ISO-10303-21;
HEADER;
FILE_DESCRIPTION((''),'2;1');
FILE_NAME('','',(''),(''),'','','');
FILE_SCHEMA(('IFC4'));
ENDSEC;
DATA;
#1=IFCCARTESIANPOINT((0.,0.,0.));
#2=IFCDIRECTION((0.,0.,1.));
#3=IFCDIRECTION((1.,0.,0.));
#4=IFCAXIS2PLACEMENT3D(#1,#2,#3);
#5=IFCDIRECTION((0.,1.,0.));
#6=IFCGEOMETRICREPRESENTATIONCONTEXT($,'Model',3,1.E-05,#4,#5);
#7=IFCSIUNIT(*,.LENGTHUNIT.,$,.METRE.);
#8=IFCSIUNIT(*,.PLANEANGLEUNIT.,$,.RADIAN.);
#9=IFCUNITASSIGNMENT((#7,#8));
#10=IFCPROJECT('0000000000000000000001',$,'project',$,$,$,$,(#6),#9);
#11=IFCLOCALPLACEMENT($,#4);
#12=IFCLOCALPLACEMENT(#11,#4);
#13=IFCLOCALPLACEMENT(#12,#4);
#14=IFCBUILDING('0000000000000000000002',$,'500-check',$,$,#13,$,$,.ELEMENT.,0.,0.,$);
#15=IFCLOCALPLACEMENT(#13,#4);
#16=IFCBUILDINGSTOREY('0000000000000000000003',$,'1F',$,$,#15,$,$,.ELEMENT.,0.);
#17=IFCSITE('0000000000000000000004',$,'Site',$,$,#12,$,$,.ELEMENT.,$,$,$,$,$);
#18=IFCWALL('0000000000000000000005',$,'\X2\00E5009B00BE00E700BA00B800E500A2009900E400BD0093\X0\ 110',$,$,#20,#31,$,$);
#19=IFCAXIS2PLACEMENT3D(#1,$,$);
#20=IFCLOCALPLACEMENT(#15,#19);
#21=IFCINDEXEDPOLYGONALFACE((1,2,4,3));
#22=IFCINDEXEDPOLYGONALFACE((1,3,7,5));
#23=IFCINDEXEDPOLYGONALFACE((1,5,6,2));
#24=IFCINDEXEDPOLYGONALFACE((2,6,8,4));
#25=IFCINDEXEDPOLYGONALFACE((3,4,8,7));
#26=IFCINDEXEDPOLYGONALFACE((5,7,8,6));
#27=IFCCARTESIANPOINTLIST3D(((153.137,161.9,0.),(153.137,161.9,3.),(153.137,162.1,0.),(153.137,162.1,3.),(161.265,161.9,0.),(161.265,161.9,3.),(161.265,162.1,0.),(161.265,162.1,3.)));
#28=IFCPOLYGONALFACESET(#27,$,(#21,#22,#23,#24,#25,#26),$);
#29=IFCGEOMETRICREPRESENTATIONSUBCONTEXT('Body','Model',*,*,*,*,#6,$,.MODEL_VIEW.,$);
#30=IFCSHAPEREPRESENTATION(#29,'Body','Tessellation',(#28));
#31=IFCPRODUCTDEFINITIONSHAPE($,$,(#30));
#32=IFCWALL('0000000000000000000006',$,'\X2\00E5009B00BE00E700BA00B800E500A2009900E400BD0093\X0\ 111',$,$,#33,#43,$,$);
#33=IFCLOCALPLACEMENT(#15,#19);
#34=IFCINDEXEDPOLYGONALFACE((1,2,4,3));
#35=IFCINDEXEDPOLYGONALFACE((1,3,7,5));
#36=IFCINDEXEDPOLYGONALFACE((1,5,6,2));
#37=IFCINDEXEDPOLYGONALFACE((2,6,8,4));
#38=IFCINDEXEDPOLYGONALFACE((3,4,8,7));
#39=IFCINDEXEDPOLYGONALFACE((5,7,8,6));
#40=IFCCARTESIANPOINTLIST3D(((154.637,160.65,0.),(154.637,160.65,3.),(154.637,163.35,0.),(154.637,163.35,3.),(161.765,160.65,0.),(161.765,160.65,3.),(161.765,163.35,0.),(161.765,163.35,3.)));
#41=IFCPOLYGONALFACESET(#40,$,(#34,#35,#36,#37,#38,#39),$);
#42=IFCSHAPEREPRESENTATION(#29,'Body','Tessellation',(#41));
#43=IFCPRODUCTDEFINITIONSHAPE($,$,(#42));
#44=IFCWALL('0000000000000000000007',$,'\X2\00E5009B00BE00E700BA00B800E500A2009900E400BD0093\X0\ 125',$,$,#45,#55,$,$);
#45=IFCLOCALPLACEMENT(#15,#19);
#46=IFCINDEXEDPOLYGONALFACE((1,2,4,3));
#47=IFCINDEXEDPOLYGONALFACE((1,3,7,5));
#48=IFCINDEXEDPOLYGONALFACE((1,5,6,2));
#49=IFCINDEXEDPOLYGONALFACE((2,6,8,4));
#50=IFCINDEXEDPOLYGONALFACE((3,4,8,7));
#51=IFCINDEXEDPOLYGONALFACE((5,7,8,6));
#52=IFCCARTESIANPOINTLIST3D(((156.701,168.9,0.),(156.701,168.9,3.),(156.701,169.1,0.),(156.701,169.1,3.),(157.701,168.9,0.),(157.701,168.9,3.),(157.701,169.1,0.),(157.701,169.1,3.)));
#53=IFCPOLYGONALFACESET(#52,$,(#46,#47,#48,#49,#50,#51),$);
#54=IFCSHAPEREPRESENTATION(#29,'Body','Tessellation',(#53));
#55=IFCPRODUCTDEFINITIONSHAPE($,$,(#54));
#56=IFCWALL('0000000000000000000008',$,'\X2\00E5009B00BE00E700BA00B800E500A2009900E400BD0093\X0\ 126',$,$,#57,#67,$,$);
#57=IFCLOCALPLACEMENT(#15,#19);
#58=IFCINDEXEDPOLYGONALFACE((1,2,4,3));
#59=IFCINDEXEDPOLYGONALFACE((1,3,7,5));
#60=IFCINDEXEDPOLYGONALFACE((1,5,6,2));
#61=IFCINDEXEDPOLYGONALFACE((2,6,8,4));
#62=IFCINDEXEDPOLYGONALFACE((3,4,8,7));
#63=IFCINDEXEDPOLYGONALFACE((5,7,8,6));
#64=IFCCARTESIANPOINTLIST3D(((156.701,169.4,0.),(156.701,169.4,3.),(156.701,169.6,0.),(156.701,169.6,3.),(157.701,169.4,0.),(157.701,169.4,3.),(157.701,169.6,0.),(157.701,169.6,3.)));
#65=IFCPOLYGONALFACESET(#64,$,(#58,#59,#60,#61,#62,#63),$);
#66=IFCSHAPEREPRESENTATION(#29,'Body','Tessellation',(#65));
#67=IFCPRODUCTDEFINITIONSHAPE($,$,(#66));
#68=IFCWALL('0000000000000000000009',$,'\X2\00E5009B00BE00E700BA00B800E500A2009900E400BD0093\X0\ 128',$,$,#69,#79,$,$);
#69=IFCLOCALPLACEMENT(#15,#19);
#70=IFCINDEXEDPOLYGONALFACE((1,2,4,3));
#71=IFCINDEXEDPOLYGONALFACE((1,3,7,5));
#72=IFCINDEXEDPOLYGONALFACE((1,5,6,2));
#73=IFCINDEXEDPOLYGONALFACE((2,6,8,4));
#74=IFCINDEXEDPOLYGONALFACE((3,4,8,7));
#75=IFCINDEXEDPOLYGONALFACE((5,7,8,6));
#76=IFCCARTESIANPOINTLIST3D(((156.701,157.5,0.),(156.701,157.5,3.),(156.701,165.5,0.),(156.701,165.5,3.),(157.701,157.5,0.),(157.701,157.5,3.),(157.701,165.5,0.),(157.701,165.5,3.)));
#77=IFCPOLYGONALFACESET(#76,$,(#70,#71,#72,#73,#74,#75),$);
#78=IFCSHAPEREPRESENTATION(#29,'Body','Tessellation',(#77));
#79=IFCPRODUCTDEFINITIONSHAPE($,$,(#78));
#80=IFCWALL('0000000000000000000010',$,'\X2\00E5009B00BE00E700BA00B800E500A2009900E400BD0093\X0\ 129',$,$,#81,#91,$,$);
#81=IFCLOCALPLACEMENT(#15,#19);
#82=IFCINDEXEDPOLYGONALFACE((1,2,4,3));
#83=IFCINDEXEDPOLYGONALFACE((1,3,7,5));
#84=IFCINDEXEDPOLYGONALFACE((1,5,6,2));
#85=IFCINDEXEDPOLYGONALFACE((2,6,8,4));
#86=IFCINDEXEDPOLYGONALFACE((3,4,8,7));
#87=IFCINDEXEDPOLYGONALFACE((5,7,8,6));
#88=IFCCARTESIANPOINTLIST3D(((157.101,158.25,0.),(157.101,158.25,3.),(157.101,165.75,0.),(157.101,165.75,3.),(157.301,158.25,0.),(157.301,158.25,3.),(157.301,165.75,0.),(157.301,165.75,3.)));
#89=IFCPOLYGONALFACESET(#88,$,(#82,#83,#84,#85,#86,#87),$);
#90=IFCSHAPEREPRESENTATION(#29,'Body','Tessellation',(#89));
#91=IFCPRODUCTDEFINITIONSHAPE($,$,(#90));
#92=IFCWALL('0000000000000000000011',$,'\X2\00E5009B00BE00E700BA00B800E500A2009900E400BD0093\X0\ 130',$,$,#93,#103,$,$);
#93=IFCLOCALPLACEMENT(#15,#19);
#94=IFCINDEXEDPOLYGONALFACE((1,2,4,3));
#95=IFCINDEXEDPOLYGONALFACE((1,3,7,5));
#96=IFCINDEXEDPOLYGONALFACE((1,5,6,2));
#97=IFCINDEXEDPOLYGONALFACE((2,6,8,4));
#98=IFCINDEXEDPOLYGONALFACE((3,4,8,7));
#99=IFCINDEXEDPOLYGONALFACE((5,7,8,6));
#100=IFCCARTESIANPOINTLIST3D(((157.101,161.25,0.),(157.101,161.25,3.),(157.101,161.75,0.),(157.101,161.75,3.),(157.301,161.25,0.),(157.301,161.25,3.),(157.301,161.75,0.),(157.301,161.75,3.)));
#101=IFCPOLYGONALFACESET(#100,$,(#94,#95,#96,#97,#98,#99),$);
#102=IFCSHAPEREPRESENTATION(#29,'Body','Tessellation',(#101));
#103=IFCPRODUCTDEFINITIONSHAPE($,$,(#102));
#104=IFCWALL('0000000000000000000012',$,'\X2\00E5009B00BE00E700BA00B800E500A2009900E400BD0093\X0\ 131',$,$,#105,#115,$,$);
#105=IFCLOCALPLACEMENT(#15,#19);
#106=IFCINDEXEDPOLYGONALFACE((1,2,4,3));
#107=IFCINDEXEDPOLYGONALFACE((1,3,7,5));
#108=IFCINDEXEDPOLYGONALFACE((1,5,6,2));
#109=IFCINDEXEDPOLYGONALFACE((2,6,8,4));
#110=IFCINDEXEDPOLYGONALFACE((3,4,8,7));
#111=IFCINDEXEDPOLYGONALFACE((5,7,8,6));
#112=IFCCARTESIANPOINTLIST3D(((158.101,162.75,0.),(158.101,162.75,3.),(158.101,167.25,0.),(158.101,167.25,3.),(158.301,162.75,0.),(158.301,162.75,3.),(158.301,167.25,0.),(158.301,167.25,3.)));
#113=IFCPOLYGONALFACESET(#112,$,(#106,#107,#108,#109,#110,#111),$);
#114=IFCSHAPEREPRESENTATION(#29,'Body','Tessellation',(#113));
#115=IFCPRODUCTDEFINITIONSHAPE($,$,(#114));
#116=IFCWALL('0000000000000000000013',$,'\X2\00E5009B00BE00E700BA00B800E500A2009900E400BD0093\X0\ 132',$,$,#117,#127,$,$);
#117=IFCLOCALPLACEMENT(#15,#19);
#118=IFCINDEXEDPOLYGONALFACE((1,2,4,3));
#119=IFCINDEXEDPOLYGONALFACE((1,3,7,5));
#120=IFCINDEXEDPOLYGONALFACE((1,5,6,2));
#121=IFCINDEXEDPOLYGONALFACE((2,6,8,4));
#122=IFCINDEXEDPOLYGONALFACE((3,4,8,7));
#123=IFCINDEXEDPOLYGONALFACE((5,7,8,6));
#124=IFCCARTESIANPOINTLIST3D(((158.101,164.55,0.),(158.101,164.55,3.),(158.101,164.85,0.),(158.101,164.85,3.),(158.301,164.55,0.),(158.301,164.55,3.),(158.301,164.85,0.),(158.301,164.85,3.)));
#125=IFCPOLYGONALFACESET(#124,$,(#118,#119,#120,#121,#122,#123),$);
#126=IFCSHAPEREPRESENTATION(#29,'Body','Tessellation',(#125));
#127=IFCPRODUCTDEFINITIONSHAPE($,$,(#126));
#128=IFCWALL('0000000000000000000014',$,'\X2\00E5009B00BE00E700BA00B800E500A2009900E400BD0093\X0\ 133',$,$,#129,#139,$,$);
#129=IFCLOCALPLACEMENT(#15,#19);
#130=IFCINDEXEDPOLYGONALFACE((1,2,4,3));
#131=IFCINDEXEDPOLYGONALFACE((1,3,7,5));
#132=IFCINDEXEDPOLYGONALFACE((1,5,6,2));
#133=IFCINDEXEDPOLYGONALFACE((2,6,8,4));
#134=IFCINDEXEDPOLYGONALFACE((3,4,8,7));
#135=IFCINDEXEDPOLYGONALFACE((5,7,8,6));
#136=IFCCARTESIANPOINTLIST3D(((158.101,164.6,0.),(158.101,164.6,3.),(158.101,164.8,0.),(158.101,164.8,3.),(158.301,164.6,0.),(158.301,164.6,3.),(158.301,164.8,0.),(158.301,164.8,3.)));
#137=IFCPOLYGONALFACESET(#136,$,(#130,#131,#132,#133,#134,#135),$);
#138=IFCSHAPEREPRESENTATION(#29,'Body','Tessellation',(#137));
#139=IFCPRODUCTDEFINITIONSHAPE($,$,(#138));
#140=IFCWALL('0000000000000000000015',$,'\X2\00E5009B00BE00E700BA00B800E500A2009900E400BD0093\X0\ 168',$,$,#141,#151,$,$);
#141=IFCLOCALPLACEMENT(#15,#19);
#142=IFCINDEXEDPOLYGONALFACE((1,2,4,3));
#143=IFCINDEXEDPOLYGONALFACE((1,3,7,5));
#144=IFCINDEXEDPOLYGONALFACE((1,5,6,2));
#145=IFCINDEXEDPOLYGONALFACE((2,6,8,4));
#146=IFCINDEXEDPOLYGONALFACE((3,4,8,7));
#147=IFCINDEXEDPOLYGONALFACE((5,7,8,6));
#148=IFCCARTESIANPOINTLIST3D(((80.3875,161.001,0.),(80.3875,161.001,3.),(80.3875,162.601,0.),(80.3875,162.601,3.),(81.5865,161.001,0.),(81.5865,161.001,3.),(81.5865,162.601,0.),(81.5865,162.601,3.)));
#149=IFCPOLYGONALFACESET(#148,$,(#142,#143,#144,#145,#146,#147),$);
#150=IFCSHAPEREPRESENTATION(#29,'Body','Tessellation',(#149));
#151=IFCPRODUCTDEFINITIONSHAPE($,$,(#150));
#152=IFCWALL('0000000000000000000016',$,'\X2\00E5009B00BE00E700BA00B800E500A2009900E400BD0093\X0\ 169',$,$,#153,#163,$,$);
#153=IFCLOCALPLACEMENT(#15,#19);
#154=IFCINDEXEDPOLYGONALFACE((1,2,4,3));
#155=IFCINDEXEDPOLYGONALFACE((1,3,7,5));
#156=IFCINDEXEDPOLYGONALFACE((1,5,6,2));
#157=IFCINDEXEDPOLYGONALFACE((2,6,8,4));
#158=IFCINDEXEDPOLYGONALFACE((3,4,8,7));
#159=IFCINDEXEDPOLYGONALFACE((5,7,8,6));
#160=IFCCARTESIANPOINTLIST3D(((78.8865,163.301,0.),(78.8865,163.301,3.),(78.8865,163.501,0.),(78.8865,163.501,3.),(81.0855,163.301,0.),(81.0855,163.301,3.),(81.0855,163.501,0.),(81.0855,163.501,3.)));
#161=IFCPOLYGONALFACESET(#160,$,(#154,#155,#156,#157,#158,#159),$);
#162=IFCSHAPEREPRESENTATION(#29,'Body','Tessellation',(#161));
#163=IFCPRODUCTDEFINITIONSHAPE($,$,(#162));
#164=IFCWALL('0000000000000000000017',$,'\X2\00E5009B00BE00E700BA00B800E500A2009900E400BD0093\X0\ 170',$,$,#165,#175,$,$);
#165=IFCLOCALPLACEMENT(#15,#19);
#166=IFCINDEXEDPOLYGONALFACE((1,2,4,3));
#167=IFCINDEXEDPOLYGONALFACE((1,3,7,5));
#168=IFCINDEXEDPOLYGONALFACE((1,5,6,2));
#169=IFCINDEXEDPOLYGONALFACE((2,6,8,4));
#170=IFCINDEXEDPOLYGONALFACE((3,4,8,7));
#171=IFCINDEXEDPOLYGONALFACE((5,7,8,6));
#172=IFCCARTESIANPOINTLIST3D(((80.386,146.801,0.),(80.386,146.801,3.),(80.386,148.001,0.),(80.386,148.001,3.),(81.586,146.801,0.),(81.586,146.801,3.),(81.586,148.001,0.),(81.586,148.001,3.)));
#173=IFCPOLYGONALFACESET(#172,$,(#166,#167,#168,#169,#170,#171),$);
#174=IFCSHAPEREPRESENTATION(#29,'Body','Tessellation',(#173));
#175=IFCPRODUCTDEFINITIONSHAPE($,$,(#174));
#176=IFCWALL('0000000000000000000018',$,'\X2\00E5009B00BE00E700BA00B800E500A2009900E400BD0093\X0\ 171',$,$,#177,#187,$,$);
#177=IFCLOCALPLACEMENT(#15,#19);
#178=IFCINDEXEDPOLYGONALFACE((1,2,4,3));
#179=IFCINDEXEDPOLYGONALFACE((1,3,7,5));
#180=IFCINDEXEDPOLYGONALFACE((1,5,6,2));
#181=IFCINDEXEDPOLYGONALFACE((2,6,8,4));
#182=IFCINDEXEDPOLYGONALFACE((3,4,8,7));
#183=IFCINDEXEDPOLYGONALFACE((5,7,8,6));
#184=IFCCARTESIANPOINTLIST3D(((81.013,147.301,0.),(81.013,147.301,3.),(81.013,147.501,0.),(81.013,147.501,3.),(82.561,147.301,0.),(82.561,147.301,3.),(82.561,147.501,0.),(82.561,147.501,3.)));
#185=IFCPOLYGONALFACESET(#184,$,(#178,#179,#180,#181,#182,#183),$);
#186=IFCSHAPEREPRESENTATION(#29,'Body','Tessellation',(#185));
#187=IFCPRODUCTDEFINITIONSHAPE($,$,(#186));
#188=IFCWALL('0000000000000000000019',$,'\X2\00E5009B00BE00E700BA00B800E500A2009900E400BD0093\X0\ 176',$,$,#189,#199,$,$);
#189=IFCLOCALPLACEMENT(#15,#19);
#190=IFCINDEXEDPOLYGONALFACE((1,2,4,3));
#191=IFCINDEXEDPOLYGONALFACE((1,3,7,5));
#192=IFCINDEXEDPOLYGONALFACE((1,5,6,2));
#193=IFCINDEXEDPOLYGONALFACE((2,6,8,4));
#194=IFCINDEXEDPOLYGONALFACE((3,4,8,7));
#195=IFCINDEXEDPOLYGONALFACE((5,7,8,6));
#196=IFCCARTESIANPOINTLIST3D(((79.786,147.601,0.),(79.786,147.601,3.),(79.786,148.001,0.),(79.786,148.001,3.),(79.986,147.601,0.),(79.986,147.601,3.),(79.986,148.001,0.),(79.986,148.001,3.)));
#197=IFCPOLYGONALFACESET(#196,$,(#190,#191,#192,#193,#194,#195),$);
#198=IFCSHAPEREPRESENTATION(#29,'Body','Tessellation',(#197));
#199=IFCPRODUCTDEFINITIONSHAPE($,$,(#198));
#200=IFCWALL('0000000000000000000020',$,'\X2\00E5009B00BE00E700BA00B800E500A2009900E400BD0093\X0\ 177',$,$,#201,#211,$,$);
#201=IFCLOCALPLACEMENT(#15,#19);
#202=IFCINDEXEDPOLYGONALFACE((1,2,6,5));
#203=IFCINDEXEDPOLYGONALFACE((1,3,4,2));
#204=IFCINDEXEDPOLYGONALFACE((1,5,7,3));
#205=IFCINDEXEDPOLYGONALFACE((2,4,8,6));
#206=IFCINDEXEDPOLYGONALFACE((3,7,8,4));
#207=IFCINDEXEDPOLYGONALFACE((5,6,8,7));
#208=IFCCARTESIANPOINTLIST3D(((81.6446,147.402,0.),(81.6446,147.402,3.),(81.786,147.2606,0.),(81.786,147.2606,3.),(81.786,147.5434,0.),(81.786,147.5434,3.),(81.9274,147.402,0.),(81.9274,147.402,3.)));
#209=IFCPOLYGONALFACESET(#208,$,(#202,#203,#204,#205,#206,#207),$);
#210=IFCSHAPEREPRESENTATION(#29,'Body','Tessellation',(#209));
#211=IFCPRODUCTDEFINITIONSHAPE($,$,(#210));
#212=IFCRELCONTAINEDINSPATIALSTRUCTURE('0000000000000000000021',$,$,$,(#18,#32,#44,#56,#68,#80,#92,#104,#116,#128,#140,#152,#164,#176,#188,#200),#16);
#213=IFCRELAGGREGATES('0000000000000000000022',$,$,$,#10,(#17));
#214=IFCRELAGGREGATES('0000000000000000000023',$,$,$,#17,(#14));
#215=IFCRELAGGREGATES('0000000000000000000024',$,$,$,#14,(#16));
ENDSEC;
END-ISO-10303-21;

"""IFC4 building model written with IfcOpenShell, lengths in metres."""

from ifc_helpers import new_model, si_unit, direction, frame, frame_2d, origin_with_axes, place, context, subcontext, project, spatial, rectangle, extrude, element, save


model = new_model("IFC4")

# Units and contexts
model_context = context("Model", 3, precision=1e-05, world=origin_with_axes(), true_north=direction((0.0, 1.0, 0.0)))
body_context = subcontext(model_context, "Body", "Model", "MODEL_VIEW")
ifc_project = project(units=[si_unit("LENGTHUNIT", "METRE"), si_unit("PLANEANGLEUNIT", "RADIAN")], contexts=[model_context])

# Site, building, storey
placement = place(None, origin_with_axes())
site_placement = place(placement, origin_with_axes())
site = spatial("IfcSite", under=ifc_project, at=site_placement, Name="Site", CompositionType="ELEMENT")
building_placement = place(site_placement, origin_with_axes())
building = spatial("IfcBuilding", under=site, at=building_placement, Name="500-check", CompositionType="ELEMENT", ElevationOfRefHeight=0.0, ElevationOfTerrain=0.0)
storey_placement = place(building_placement, origin_with_axes())
storey = spatial("IfcBuildingStorey", under=building, at=storey_placement, Name="1F", CompositionType="ELEMENT", Elevation=0.0)

# Walls
wall_1_placement = place(storey_placement, frame((157.201, 162.0, 0.0), z_axis=(0.0, 0.0, 1.0), x_axis=(1.0, 0.0, 0.0)))
element("IfcWall", 1, at=wall_1_placement, inside=storey, Name="å\u009b¾çº¸å¢\u0099ä½\u0093 110", context=body_context, shape_type="SweptSolid", body=[
    extrude(rectangle(XDim=8.128, YDim=0.2, at=frame_2d((0.0, 0.0), x_axis=(1.0, 0.0, 0.0))), frame((0.0, 0.0, 0.0), z_axis=(0.0, 0.0, 1.0)), (0.0, 0.0, 1.0), 3.0),
])
wall_2_placement = place(storey_placement, frame((158.201, 162.0, 0.0), z_axis=(0.0, 0.0, 1.0), x_axis=(1.0, 0.0, 0.0)))
element("IfcWall", 2, at=wall_2_placement, inside=storey, Name="å\u009b¾çº¸å¢\u0099ä½\u0093 111", context=body_context, shape_type="SweptSolid", body=[
    extrude(rectangle(XDim=7.128, YDim=2.7, at=frame_2d((0.0, 0.0), x_axis=(1.0, 0.0, 0.0))), frame((0.0, 0.0, 0.0), z_axis=(0.0, 0.0, 1.0)), (0.0, 0.0, 1.0), 3.0),
])
for number, where, z_axis, x_axis, name in (
    (3, (157.201, 169.0, 0.0), (0.0, 0.0, 1.0), (1.0, 0.0, 0.0), "å\u009b¾çº¸å¢\u0099ä½\u0093 125"),
    (4, (157.201, 169.5, 0.0), (0.0, 0.0, 1.0), (1.0, 0.0, 0.0), "å\u009b¾çº¸å¢\u0099ä½\u0093 126"),
):
    element("IfcWall", number, at=place(storey_placement, frame(where, z_axis=z_axis, x_axis=x_axis)), inside=storey, Name=name, context=body_context, shape_type="SweptSolid", body=[
        extrude(rectangle(XDim=1.0, YDim=0.2, at=frame_2d((0.0, 0.0), x_axis=(1.0, 0.0, 0.0))), frame((0.0, 0.0, 0.0), z_axis=(0.0, 0.0, 1.0)), (0.0, 0.0, 1.0), 3.0),
    ])
wall_3_placement = place(storey_placement, frame((157.201, 161.5, 0.0), z_axis=(0.0, 0.0, 1.0), x_axis=(1.0, 0.0, 0.0)))
element("IfcWall", 5, at=wall_3_placement, inside=storey, Name="å\u009b¾çº¸å¢\u0099ä½\u0093 128", context=body_context, shape_type="SweptSolid", body=[
    extrude(rectangle(XDim=1.0, YDim=8.0, at=frame_2d((0.0, 0.0), x_axis=(1.0, 0.0, 0.0))), frame((0.0, 0.0, 0.0), z_axis=(0.0, 0.0, 1.0)), (0.0, 0.0, 1.0), 3.0),
])
wall_4_placement = place(storey_placement, frame((157.201, 162.0, 0.0), z_axis=(0.0, 0.0, 1.0), x_axis=(0.0, 1.0, 0.0)))
element("IfcWall", 6, at=wall_4_placement, inside=storey, Name="å\u009b¾çº¸å¢\u0099ä½\u0093 129", context=body_context, shape_type="SweptSolid", body=[
    extrude(rectangle(XDim=7.5, YDim=0.2, at=frame_2d((0.0, 0.0), x_axis=(1.0, 0.0, 0.0))), frame((0.0, 0.0, 0.0), z_axis=(0.0, 0.0, 1.0)), (0.0, 0.0, 1.0), 3.0),
])
wall_5_placement = place(storey_placement, frame((157.201, 161.5, 0.0), z_axis=(0.0, 0.0, 1.0), x_axis=(0.0, 1.0, 0.0)))
element("IfcWall", 7, at=wall_5_placement, inside=storey, Name="å\u009b¾çº¸å¢\u0099ä½\u0093 130", context=body_context, shape_type="SweptSolid", body=[
    extrude(rectangle(XDim=0.5, YDim=0.2, at=frame_2d((0.0, 0.0), x_axis=(1.0, 0.0, 0.0))), frame((0.0, 0.0, 0.0), z_axis=(0.0, 0.0, 1.0)), (0.0, 0.0, 1.0), 3.0),
])
wall_6_placement = place(storey_placement, frame((158.201, 165.0, 0.0), z_axis=(0.0, 0.0, 1.0), x_axis=(0.0, 1.0, 0.0)))
element("IfcWall", 8, at=wall_6_placement, inside=storey, Name="å\u009b¾çº¸å¢\u0099ä½\u0093 131", context=body_context, shape_type="SweptSolid", body=[
    extrude(rectangle(XDim=4.5, YDim=0.2, at=frame_2d((0.0, 0.0), x_axis=(1.0, 0.0, 0.0))), frame((0.0, 0.0, 0.0), z_axis=(0.0, 0.0, 1.0)), (0.0, 0.0, 1.0), 3.0),
])
wall_7_placement = place(storey_placement, frame((158.201, 164.7, 0.0), z_axis=(0.0, 0.0, 1.0), x_axis=(1.0, 0.0, 0.0)))
element("IfcWall", 9, at=wall_7_placement, inside=storey, Name="å\u009b¾çº¸å¢\u0099ä½\u0093 132", context=body_context, shape_type="SweptSolid", body=[
    extrude(rectangle(XDim=0.2, YDim=0.3, at=frame_2d((0.0, 0.0), x_axis=(1.0, 0.0, 0.0))), frame((0.0, 0.0, 0.0), z_axis=(0.0, 0.0, 1.0)), (0.0, 0.0, 1.0), 3.0),
])
wall_8_placement = place(storey_placement, frame((158.201, 164.7, 0.0), z_axis=(0.0, 0.0, 1.0), x_axis=(1.0, 0.0, 0.0)))
element("IfcWall", 10, at=wall_8_placement, inside=storey, Name="å\u009b¾çº¸å¢\u0099ä½\u0093 133", context=body_context, shape_type="SweptSolid", body=[
    extrude(rectangle(XDim=0.2, YDim=0.2, at=frame_2d((0.0, 0.0), x_axis=(1.0, 0.0, 0.0))), frame((0.0, 0.0, 0.0), z_axis=(0.0, 0.0, 1.0)), (0.0, 0.0, 1.0), 3.0),
])
wall_9_placement = place(storey_placement, frame((80.987, 161.801, 0.0), z_axis=(0.0, 0.0, 1.0), x_axis=(1.0, 0.0, 0.0)))
element("IfcWall", 11, at=wall_9_placement, inside=storey, Name="å\u009b¾çº¸å¢\u0099ä½\u0093 168", context=body_context, shape_type="SweptSolid", body=[
    extrude(rectangle(XDim=1.199, YDim=1.6, at=frame_2d((0.0, 0.0), x_axis=(1.0, 0.0, 0.0))), frame((0.0, 0.0, 0.0), z_axis=(0.0, 0.0, 1.0)), (0.0, 0.0, 1.0), 3.0),
])
wall_10_placement = place(storey_placement, frame((79.986, 163.401, 0.0), z_axis=(0.0, 0.0, 1.0), x_axis=(1.0, 0.0, 0.0)))
element("IfcWall", 12, at=wall_10_placement, inside=storey, Name="å\u009b¾çº¸å¢\u0099ä½\u0093 169", context=body_context, shape_type="SweptSolid", body=[
    extrude(rectangle(XDim=2.199, YDim=0.2, at=frame_2d((0.0, 0.0), x_axis=(1.0, 0.0, 0.0))), frame((0.0, 0.0, 0.0), z_axis=(0.0, 0.0, 1.0)), (0.0, 0.0, 1.0), 3.0),
])
wall_11_placement = place(storey_placement, frame((80.986, 147.401, 0.0), z_axis=(0.0, 0.0, 1.0), x_axis=(1.0, 0.0, 0.0)))
element("IfcWall", 13, at=wall_11_placement, inside=storey, Name="å\u009b¾çº¸å¢\u0099ä½\u0093 170", context=body_context, shape_type="SweptSolid", body=[
    extrude(rectangle(XDim=1.2, YDim=1.2, at=frame_2d((0.0, 0.0), x_axis=(1.0, 0.0, 0.0))), frame((0.0, 0.0, 0.0), z_axis=(0.0, 0.0, 1.0)), (0.0, 0.0, 1.0), 3.0),
])
wall_12_placement = place(storey_placement, frame((81.787, 147.401, 0.0), z_axis=(0.0, 0.0, 1.0), x_axis=(1.0, 0.0, 0.0)))
element("IfcWall", 14, at=wall_12_placement, inside=storey, Name="å\u009b¾çº¸å¢\u0099ä½\u0093 171", context=body_context, shape_type="SweptSolid", body=[
    extrude(rectangle(XDim=1.548, YDim=0.2, at=frame_2d((0.0, 0.0), x_axis=(1.0, 0.0, 0.0))), frame((0.0, 0.0, 0.0), z_axis=(0.0, 0.0, 1.0)), (0.0, 0.0, 1.0), 3.0),
])
wall_13_placement = place(storey_placement, frame((79.886, 147.801, 0.0), z_axis=(0.0, 0.0, 1.0), x_axis=(0.0, -1.0, 0.0)))
element("IfcWall", 15, at=wall_13_placement, inside=storey, Name="å\u009b¾çº¸å¢\u0099ä½\u0093 176", context=body_context, shape_type="SweptSolid", body=[
    extrude(rectangle(XDim=0.4, YDim=0.2, at=frame_2d((0.0, 0.0), x_axis=(1.0, 0.0, 0.0))), frame((0.0, 0.0, 0.0), z_axis=(0.0, 0.0, 1.0)), (0.0, 0.0, 1.0), 3.0),
])
wall_14_placement = place(storey_placement, frame((81.786, 147.402, 0.0), z_axis=(0.0, 0.0, 1.0), x_axis=(0.707107, -0.707107, 0.0)))
element("IfcWall", 16, at=wall_14_placement, inside=storey, Name="å\u009b¾çº¸å¢\u0099ä½\u0093 177", context=body_context, shape_type="SweptSolid", body=[
    extrude(rectangle(XDim=0.2, YDim=0.2, at=frame_2d((0.0, 0.0), x_axis=(1.0, 0.0, 0.0))), frame((0.0, 0.0, 0.0), z_axis=(0.0, 0.0, 1.0)), (0.0, 0.0, 1.0), 3.0),
])

save(model, "model.ifc")
